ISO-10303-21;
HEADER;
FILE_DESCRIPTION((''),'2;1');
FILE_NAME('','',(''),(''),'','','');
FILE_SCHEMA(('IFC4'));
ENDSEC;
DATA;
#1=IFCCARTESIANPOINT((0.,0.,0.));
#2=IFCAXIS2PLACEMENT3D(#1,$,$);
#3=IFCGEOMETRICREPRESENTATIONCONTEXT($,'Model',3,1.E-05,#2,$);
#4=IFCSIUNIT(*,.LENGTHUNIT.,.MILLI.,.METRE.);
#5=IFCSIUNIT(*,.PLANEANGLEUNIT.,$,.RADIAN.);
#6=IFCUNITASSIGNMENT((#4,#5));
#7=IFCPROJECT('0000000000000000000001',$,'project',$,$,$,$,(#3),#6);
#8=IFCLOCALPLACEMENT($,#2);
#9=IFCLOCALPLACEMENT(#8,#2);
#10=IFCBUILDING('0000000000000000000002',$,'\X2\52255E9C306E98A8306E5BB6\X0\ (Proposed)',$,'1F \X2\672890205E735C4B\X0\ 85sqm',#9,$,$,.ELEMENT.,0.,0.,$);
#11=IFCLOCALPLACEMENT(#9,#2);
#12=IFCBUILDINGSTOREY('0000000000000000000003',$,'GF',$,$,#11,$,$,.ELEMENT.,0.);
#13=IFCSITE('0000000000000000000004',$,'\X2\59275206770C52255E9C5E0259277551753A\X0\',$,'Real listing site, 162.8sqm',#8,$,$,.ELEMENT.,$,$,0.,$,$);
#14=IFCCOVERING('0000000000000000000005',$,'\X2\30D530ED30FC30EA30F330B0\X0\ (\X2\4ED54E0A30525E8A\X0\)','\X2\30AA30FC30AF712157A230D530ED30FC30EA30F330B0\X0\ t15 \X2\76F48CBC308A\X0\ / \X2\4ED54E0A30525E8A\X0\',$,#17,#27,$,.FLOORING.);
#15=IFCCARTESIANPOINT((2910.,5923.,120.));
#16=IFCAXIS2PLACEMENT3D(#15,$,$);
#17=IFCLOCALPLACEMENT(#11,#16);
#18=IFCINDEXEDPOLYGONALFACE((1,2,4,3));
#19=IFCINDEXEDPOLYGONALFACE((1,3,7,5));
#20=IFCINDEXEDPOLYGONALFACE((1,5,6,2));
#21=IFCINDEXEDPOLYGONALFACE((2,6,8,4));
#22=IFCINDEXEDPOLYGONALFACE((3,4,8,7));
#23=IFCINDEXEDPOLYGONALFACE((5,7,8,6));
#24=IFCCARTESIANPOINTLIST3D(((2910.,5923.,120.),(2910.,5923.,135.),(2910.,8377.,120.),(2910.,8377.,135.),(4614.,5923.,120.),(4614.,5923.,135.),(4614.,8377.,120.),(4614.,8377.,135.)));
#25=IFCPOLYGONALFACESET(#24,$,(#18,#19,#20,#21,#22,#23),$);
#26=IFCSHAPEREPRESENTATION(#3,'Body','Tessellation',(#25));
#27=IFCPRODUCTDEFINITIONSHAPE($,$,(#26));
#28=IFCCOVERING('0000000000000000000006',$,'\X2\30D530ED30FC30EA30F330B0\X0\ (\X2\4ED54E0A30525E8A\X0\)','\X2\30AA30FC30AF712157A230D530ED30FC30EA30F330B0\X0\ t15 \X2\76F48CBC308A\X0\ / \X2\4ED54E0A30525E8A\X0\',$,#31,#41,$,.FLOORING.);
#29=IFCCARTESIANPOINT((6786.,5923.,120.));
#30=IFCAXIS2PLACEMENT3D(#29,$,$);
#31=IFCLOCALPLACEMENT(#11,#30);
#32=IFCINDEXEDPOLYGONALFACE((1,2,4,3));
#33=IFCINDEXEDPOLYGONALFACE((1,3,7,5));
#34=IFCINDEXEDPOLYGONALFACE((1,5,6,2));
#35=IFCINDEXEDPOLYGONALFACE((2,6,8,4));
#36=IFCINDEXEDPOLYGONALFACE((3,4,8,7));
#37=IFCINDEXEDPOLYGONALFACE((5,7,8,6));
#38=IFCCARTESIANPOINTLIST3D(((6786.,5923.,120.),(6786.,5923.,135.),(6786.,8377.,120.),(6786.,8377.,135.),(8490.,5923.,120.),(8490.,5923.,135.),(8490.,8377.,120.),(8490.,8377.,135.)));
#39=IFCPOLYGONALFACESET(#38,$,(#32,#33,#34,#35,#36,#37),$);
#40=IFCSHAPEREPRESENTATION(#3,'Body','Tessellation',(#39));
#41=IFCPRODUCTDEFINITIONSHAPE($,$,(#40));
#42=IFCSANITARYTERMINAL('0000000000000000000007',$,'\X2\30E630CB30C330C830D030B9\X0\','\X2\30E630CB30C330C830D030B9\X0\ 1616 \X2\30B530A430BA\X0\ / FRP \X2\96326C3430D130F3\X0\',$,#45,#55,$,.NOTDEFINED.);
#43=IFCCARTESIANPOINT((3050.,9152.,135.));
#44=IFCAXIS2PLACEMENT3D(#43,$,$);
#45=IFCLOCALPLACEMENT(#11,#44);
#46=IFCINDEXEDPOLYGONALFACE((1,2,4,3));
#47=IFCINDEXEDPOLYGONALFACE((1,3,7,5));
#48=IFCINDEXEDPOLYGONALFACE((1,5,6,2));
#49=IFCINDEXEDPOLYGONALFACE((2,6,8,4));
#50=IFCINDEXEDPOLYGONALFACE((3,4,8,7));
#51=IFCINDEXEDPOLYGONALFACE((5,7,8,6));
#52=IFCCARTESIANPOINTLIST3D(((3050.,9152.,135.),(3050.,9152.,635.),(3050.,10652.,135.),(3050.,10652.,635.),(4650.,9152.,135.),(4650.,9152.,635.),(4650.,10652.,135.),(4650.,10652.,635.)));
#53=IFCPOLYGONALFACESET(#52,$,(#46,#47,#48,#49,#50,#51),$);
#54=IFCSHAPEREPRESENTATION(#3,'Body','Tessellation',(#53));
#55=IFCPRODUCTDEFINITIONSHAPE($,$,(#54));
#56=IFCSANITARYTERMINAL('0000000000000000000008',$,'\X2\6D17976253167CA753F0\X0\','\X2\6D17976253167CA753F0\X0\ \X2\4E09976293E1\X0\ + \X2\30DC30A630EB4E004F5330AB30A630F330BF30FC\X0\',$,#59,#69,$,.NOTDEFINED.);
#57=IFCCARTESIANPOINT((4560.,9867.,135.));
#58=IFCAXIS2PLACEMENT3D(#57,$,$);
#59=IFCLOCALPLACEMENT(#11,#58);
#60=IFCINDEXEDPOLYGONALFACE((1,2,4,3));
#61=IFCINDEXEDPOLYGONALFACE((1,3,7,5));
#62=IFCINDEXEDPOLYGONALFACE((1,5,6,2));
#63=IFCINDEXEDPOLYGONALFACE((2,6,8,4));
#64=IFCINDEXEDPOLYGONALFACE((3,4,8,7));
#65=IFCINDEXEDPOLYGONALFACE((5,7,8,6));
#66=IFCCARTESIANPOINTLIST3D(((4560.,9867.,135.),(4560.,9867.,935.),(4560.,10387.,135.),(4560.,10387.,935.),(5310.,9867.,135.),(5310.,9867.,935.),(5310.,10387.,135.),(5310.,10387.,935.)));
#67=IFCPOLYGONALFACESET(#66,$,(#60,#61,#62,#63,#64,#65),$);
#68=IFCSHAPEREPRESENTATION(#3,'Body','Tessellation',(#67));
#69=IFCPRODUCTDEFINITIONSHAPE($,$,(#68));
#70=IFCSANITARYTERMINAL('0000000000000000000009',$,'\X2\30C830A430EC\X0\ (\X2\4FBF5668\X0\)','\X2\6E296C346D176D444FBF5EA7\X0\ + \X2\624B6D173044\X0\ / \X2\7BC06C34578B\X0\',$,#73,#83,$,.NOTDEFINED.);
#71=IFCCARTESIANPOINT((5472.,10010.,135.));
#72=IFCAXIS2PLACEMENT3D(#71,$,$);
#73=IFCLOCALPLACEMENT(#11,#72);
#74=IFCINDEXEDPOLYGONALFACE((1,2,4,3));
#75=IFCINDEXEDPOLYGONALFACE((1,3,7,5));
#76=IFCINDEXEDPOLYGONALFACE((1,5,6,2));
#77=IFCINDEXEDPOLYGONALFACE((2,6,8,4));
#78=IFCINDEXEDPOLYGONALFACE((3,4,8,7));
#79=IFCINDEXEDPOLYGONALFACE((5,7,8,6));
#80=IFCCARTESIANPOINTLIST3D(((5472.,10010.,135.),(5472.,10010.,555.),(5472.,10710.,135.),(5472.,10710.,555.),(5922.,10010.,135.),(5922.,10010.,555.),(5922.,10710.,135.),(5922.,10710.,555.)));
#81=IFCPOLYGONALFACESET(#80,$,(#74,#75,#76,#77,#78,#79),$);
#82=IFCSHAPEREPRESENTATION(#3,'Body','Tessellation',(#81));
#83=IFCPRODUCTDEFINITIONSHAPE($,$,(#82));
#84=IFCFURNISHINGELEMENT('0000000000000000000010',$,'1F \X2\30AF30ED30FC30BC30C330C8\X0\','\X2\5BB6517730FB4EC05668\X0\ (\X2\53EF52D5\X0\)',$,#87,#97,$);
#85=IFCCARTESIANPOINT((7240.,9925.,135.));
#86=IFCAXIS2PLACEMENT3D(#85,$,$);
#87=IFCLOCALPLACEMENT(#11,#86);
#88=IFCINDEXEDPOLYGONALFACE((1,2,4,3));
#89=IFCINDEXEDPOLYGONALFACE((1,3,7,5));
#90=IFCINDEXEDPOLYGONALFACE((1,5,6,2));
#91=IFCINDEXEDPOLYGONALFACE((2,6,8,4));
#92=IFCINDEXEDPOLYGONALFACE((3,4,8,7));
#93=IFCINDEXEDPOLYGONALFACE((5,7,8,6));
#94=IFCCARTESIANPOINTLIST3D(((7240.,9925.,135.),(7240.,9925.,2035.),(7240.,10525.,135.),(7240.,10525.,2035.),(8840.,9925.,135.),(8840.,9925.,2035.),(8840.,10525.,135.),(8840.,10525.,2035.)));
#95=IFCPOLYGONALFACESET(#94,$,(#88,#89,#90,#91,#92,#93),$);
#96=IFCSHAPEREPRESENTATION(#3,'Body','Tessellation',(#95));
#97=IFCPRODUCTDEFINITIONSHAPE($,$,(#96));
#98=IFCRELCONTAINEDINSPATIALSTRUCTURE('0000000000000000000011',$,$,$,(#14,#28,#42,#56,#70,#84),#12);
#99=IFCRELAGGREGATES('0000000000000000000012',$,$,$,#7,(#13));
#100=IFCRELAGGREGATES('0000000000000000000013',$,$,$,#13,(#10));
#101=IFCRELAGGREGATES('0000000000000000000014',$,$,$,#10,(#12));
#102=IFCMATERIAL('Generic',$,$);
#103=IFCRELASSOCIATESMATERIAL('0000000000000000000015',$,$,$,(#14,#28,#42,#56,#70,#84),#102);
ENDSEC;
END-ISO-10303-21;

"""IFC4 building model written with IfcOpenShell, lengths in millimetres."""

from ifc_helpers import new_model, si_unit, frame, frame_2d, origin, place, context, project, spatial, rectangle, extrude, material, element, save


model = new_model("IFC4")

# Units and contexts
model_context = context("Model", 3, precision=1e-05, world=origin())
ifc_project = project(units=[si_unit("LENGTHUNIT", "METRE", prefix="MILLI"), si_unit("PLANEANGLEUNIT", "RADIAN")], contexts=[model_context])

# Site, building, storey
site_placement = place(None, origin())
site = spatial("IfcSite", under=ifc_project, at=site_placement, Name="大分県別府市大畑町", ObjectType="Real listing site, 162.8sqm", CompositionType="ELEMENT", RefElevation=0.0)
building_placement = place(site_placement, origin())
building = spatial("IfcBuilding", under=site, at=building_placement, Name="別府の風の家 (Proposed)", ObjectType="1F 木造平屋 85sqm", CompositionType="ELEMENT", ElevationOfRefHeight=0.0, ElevationOfTerrain=0.0)
storey_placement = place(building_placement, origin())
storey = spatial("IfcBuildingStorey", under=building, at=storey_placement, Name="GF", CompositionType="ELEMENT", Elevation=0.0)

# Coverings
ifc_material_1 = material(Name="Generic")
covering_1_placement = place(storey_placement, frame((2910.0, 5923.0, 120.0)))
element("IfcCovering", 1, at=covering_1_placement, inside=storey, material=ifc_material_1, Name="フローリング (仕上げ床)", Description="オーク無垢フローリング t15 直貼り / 仕上げ床", PredefinedType="FLOORING", context=model_context, shape_type="SweptSolid", body=[
    extrude(rectangle(XDim=1704.0, YDim=2454.0, at=frame_2d((852.0, 1227.0))), frame((2910.0, 5923.0, 120.0)), (0.0, 0.0, 1.0), 15.0),
])
covering_2_placement = place(storey_placement, frame((6786.0, 5923.0, 120.0)))
element("IfcCovering", 2, at=covering_2_placement, inside=storey, material=ifc_material_1, Name="フローリング (仕上げ床)", Description="オーク無垢フローリング t15 直貼り / 仕上げ床", PredefinedType="FLOORING", context=model_context, shape_type="SweptSolid", body=[
    extrude(rectangle(XDim=1704.0, YDim=2454.0, at=frame_2d((852.0, 1227.0))), frame((6786.0, 5923.0, 120.0)), (0.0, 0.0, 1.0), 15.0),
])

# Sanitary terminals
sanitary_terminal_1_placement = place(storey_placement, frame((3050.0, 9152.0, 135.0)))
element("IfcSanitaryTerminal", 3, at=sanitary_terminal_1_placement, inside=storey, material=ifc_material_1, Name="ユニットバス", Description="ユニットバス 1616 サイズ / FRP 防水パン", PredefinedType="NOTDEFINED", context=model_context, shape_type="SweptSolid", body=[
    extrude(rectangle(XDim=1600.0, YDim=1500.0, at=frame_2d((800.0, 750.0))), frame((3050.0, 9152.0, 135.0)), (0.0, 0.0, 1.0), 500.0),
])
sanitary_terminal_2_placement = place(storey_placement, frame((4560.0, 9867.0, 135.0)))
element("IfcSanitaryTerminal", 4, at=sanitary_terminal_2_placement, inside=storey, material=ifc_material_1, Name="洗面化粧台", Description="洗面化粧台 三面鏡 + ボウル一体カウンター", PredefinedType="NOTDEFINED", context=model_context, shape_type="SweptSolid", body=[
    extrude(rectangle(XDim=750.0, YDim=520.0, at=frame_2d((375.0, 260.0))), frame((4560.0, 9867.0, 135.0)), (0.0, 0.0, 1.0), 800.0),
])
sanitary_terminal_3_placement = place(storey_placement, frame((5472.0, 10010.0, 135.0)))
element("IfcSanitaryTerminal", 5, at=sanitary_terminal_3_placement, inside=storey, material=ifc_material_1, Name="トイレ (便器)", Description="温水洗浄便座 + 手洗い / 節水型", PredefinedType="NOTDEFINED", context=model_context, shape_type="SweptSolid", body=[
    extrude(rectangle(XDim=450.0, YDim=700.0, at=frame_2d((225.0, 350.0))), frame((5472.0, 10010.0, 135.0)), (0.0, 0.0, 1.0), 420.0),
])

# Furnishing element
furnishing_placement = place(storey_placement, frame((7240.0, 9925.0, 135.0)))
element("IfcFurnishingElement", 6, at=furnishing_placement, inside=storey, material=ifc_material_1, Name="1F クローゼット", Description="家具・什器 (可動)", context=model_context, shape_type="SweptSolid", body=[
    extrude(rectangle(XDim=1600.0, YDim=600.0, at=frame_2d((800.0, 300.0))), frame((7240.0, 9925.0, 135.0)), (0.0, 0.0, 1.0), 1900.0),
])

save(model, "model.ifc")
